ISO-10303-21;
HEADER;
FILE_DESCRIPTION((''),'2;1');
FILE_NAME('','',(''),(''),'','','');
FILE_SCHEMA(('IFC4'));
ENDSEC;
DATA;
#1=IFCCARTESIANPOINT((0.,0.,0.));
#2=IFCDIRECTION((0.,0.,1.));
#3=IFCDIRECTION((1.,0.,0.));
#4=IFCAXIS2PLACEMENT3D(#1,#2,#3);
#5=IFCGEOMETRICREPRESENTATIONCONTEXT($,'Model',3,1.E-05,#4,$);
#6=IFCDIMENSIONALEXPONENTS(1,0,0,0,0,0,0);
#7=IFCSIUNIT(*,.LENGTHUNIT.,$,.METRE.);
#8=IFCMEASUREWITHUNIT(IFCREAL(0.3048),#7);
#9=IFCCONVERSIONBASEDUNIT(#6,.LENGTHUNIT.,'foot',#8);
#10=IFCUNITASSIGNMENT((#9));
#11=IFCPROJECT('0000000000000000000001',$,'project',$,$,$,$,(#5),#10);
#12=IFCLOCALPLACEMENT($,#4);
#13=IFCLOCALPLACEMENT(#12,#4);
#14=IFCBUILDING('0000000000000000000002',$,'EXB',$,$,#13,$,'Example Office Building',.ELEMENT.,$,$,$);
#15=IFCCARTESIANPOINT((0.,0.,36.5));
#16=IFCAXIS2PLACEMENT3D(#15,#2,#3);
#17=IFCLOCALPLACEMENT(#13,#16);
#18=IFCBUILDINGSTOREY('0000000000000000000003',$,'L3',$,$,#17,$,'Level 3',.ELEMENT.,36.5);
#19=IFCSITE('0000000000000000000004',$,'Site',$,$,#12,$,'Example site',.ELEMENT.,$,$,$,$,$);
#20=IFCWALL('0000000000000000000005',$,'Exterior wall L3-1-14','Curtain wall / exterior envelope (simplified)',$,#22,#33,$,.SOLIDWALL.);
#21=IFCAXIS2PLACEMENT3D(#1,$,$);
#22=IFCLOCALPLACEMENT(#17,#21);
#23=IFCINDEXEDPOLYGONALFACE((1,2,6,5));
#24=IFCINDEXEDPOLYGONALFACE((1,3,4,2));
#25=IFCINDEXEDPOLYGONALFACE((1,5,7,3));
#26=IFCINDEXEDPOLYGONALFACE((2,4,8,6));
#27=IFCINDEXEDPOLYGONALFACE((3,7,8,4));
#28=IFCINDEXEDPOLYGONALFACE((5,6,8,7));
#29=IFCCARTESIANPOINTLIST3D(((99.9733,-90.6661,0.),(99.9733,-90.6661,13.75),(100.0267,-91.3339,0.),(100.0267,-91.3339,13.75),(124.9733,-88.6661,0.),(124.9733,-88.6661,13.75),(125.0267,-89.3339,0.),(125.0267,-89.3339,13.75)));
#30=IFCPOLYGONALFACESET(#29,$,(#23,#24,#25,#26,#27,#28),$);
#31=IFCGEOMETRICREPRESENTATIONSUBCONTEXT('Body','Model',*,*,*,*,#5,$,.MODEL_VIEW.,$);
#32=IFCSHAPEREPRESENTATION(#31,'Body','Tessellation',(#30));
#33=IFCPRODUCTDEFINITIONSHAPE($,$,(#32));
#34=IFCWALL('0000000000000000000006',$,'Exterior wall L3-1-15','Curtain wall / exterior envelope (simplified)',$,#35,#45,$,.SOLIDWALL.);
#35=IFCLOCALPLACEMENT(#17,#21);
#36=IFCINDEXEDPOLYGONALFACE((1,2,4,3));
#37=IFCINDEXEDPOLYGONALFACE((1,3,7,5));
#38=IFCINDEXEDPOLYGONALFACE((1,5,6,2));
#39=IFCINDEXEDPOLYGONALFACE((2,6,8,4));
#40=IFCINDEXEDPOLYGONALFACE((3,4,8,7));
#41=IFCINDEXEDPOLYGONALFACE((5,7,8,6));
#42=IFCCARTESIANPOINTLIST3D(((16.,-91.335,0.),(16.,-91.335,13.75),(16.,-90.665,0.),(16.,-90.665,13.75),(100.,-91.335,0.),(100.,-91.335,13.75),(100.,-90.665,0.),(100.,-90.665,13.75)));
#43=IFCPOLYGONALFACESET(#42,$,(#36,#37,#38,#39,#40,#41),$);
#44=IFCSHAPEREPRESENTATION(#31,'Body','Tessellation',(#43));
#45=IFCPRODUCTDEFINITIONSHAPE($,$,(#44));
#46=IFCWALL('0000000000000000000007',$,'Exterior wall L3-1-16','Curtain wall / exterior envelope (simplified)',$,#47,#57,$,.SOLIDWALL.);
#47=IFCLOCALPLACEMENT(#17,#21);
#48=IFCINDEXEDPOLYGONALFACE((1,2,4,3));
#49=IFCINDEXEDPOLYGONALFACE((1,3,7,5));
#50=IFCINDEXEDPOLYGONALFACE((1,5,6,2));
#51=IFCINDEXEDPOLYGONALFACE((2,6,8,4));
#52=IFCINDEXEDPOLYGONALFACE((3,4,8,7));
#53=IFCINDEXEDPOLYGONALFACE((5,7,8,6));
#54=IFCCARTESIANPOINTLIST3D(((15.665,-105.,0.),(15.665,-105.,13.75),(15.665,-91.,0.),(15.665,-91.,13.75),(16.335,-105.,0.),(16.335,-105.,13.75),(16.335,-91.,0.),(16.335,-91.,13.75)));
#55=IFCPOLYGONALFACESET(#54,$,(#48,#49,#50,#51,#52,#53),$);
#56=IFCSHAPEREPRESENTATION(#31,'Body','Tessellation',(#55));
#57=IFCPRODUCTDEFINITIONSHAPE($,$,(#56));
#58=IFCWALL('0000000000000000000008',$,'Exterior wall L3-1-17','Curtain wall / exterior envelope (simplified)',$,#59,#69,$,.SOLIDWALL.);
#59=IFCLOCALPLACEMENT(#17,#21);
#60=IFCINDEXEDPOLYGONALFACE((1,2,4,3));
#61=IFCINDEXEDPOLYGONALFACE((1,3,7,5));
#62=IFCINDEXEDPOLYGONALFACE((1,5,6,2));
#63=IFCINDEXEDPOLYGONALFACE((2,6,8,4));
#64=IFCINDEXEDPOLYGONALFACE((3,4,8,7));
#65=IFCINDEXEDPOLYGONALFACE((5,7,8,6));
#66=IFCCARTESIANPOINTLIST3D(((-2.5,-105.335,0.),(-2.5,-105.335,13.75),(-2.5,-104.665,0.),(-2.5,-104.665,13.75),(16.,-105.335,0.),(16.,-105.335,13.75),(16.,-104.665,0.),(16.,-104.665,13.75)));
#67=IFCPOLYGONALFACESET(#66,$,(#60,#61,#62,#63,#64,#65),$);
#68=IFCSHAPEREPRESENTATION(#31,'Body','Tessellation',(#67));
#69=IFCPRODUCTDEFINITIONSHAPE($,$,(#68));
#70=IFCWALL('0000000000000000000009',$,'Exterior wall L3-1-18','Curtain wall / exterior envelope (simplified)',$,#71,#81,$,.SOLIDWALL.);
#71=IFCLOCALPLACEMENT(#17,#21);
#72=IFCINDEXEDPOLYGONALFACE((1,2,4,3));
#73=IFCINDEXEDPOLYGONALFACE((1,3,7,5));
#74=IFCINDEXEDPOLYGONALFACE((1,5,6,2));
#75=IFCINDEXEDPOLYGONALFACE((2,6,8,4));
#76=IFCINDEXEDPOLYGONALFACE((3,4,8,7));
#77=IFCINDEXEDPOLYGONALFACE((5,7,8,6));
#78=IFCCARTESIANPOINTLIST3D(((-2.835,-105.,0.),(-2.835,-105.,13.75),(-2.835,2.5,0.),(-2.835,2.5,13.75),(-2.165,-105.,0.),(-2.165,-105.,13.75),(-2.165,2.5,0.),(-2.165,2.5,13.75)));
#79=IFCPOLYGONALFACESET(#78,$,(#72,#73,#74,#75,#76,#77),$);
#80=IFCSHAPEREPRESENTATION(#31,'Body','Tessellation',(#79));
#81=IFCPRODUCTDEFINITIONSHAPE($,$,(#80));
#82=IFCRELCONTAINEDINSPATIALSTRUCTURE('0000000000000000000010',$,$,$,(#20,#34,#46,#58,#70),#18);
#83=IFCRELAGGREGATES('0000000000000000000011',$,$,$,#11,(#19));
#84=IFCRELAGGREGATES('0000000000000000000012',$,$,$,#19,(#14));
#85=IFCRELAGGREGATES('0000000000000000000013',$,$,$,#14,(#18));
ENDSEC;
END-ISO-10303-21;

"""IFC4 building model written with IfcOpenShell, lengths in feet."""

from ifc_helpers import new_model, entity, si_unit, converted_unit, frame, frame_2d, origin, origin_with_axes, place, context, subcontext, project, spatial, rectangle, extrude, element, save


model = new_model("IFC4")

# Units and contexts
model_context = context("Model", 3, precision=1e-05, world=origin_with_axes())
body_context = subcontext(model_context, "Body", "Model", "MODEL_VIEW")
ifc_project = project(units=[converted_unit("LENGTHUNIT", "foot", entity("IfcReal", 0.3048), si_unit("LENGTHUNIT", "METRE"), dimensions=[1, 0, 0, 0, 0, 0, 0])], contexts=[model_context])

# Site, building, storey
site_placement = place(None, origin_with_axes())
site = spatial("IfcSite", under=ifc_project, at=site_placement, Name="Site", LongName="Example site", CompositionType="ELEMENT")
building_placement = place(site_placement, origin_with_axes())
building = spatial("IfcBuilding", under=site, at=building_placement, Name="EXB", LongName="Example Office Building", CompositionType="ELEMENT")
storey_placement = place(building_placement, frame((0.0, 0.0, 36.5), z_axis=(0.0, 0.0, 1.0), x_axis=(1.0, 0.0, 0.0)))
storey = spatial("IfcBuildingStorey", under=building, at=storey_placement, Name="L3", LongName="Level 3", CompositionType="ELEMENT", Elevation=36.5)

# Walls
wall_1_placement = place(storey_placement, frame((125.0, -89.0, 0.0), z_axis=(0.0, 0.0, 1.0), x_axis=(-0.996815, -0.079745, 0.0)))
element("IfcWall", 1, at=wall_1_placement, inside=storey, Name="Exterior wall L3-1-14", Description="Curtain wall / exterior envelope (simplified)", PredefinedType="SOLIDWALL", context=body_context, shape_type="SweptSolid", body=[
    extrude(rectangle(XDim=25.0799, YDim=0.67, at=frame_2d((12.5399, 0.0))), origin(), (0.0, 0.0, 1.0), 13.75),
])
wall_2_placement = place(storey_placement, frame((100.0, -91.0, 0.0), z_axis=(0.0, 0.0, 1.0), x_axis=(-1.0, 0.0, 0.0)))
element("IfcWall", 2, at=wall_2_placement, inside=storey, Name="Exterior wall L3-1-15", Description="Curtain wall / exterior envelope (simplified)", PredefinedType="SOLIDWALL", context=body_context, shape_type="SweptSolid", body=[
    extrude(rectangle(XDim=84.0, YDim=0.67, at=frame_2d((42.0, 0.0))), origin(), (0.0, 0.0, 1.0), 13.75),
])
wall_3_placement = place(storey_placement, frame((16.0, -91.0, 0.0), z_axis=(0.0, 0.0, 1.0), x_axis=(0.0, -1.0, 0.0)))
element("IfcWall", 3, at=wall_3_placement, inside=storey, Name="Exterior wall L3-1-16", Description="Curtain wall / exterior envelope (simplified)", PredefinedType="SOLIDWALL", context=body_context, shape_type="SweptSolid", body=[
    extrude(rectangle(XDim=14.0, YDim=0.67, at=frame_2d((7.0, 0.0))), origin(), (0.0, 0.0, 1.0), 13.75),
])
wall_4_placement = place(storey_placement, frame((16.0, -105.0, 0.0), z_axis=(0.0, 0.0, 1.0), x_axis=(-1.0, 0.0, 0.0)))
element("IfcWall", 4, at=wall_4_placement, inside=storey, Name="Exterior wall L3-1-17", Description="Curtain wall / exterior envelope (simplified)", PredefinedType="SOLIDWALL", context=body_context, shape_type="SweptSolid", body=[
    extrude(rectangle(XDim=18.5, YDim=0.67, at=frame_2d((9.25, 0.0))), origin(), (0.0, 0.0, 1.0), 13.75),
])
wall_5_placement = place(storey_placement, frame((-2.5, -105.0, 0.0), z_axis=(0.0, 0.0, 1.0), x_axis=(0.0, 1.0, 0.0)))
element("IfcWall", 5, at=wall_5_placement, inside=storey, Name="Exterior wall L3-1-18", Description="Curtain wall / exterior envelope (simplified)", PredefinedType="SOLIDWALL", context=body_context, shape_type="SweptSolid", body=[
    extrude(rectangle(XDim=107.5, YDim=0.67, at=frame_2d((53.75, 0.0))), origin(), (0.0, 0.0, 1.0), 13.75),
])

save(model, "model.ifc")
